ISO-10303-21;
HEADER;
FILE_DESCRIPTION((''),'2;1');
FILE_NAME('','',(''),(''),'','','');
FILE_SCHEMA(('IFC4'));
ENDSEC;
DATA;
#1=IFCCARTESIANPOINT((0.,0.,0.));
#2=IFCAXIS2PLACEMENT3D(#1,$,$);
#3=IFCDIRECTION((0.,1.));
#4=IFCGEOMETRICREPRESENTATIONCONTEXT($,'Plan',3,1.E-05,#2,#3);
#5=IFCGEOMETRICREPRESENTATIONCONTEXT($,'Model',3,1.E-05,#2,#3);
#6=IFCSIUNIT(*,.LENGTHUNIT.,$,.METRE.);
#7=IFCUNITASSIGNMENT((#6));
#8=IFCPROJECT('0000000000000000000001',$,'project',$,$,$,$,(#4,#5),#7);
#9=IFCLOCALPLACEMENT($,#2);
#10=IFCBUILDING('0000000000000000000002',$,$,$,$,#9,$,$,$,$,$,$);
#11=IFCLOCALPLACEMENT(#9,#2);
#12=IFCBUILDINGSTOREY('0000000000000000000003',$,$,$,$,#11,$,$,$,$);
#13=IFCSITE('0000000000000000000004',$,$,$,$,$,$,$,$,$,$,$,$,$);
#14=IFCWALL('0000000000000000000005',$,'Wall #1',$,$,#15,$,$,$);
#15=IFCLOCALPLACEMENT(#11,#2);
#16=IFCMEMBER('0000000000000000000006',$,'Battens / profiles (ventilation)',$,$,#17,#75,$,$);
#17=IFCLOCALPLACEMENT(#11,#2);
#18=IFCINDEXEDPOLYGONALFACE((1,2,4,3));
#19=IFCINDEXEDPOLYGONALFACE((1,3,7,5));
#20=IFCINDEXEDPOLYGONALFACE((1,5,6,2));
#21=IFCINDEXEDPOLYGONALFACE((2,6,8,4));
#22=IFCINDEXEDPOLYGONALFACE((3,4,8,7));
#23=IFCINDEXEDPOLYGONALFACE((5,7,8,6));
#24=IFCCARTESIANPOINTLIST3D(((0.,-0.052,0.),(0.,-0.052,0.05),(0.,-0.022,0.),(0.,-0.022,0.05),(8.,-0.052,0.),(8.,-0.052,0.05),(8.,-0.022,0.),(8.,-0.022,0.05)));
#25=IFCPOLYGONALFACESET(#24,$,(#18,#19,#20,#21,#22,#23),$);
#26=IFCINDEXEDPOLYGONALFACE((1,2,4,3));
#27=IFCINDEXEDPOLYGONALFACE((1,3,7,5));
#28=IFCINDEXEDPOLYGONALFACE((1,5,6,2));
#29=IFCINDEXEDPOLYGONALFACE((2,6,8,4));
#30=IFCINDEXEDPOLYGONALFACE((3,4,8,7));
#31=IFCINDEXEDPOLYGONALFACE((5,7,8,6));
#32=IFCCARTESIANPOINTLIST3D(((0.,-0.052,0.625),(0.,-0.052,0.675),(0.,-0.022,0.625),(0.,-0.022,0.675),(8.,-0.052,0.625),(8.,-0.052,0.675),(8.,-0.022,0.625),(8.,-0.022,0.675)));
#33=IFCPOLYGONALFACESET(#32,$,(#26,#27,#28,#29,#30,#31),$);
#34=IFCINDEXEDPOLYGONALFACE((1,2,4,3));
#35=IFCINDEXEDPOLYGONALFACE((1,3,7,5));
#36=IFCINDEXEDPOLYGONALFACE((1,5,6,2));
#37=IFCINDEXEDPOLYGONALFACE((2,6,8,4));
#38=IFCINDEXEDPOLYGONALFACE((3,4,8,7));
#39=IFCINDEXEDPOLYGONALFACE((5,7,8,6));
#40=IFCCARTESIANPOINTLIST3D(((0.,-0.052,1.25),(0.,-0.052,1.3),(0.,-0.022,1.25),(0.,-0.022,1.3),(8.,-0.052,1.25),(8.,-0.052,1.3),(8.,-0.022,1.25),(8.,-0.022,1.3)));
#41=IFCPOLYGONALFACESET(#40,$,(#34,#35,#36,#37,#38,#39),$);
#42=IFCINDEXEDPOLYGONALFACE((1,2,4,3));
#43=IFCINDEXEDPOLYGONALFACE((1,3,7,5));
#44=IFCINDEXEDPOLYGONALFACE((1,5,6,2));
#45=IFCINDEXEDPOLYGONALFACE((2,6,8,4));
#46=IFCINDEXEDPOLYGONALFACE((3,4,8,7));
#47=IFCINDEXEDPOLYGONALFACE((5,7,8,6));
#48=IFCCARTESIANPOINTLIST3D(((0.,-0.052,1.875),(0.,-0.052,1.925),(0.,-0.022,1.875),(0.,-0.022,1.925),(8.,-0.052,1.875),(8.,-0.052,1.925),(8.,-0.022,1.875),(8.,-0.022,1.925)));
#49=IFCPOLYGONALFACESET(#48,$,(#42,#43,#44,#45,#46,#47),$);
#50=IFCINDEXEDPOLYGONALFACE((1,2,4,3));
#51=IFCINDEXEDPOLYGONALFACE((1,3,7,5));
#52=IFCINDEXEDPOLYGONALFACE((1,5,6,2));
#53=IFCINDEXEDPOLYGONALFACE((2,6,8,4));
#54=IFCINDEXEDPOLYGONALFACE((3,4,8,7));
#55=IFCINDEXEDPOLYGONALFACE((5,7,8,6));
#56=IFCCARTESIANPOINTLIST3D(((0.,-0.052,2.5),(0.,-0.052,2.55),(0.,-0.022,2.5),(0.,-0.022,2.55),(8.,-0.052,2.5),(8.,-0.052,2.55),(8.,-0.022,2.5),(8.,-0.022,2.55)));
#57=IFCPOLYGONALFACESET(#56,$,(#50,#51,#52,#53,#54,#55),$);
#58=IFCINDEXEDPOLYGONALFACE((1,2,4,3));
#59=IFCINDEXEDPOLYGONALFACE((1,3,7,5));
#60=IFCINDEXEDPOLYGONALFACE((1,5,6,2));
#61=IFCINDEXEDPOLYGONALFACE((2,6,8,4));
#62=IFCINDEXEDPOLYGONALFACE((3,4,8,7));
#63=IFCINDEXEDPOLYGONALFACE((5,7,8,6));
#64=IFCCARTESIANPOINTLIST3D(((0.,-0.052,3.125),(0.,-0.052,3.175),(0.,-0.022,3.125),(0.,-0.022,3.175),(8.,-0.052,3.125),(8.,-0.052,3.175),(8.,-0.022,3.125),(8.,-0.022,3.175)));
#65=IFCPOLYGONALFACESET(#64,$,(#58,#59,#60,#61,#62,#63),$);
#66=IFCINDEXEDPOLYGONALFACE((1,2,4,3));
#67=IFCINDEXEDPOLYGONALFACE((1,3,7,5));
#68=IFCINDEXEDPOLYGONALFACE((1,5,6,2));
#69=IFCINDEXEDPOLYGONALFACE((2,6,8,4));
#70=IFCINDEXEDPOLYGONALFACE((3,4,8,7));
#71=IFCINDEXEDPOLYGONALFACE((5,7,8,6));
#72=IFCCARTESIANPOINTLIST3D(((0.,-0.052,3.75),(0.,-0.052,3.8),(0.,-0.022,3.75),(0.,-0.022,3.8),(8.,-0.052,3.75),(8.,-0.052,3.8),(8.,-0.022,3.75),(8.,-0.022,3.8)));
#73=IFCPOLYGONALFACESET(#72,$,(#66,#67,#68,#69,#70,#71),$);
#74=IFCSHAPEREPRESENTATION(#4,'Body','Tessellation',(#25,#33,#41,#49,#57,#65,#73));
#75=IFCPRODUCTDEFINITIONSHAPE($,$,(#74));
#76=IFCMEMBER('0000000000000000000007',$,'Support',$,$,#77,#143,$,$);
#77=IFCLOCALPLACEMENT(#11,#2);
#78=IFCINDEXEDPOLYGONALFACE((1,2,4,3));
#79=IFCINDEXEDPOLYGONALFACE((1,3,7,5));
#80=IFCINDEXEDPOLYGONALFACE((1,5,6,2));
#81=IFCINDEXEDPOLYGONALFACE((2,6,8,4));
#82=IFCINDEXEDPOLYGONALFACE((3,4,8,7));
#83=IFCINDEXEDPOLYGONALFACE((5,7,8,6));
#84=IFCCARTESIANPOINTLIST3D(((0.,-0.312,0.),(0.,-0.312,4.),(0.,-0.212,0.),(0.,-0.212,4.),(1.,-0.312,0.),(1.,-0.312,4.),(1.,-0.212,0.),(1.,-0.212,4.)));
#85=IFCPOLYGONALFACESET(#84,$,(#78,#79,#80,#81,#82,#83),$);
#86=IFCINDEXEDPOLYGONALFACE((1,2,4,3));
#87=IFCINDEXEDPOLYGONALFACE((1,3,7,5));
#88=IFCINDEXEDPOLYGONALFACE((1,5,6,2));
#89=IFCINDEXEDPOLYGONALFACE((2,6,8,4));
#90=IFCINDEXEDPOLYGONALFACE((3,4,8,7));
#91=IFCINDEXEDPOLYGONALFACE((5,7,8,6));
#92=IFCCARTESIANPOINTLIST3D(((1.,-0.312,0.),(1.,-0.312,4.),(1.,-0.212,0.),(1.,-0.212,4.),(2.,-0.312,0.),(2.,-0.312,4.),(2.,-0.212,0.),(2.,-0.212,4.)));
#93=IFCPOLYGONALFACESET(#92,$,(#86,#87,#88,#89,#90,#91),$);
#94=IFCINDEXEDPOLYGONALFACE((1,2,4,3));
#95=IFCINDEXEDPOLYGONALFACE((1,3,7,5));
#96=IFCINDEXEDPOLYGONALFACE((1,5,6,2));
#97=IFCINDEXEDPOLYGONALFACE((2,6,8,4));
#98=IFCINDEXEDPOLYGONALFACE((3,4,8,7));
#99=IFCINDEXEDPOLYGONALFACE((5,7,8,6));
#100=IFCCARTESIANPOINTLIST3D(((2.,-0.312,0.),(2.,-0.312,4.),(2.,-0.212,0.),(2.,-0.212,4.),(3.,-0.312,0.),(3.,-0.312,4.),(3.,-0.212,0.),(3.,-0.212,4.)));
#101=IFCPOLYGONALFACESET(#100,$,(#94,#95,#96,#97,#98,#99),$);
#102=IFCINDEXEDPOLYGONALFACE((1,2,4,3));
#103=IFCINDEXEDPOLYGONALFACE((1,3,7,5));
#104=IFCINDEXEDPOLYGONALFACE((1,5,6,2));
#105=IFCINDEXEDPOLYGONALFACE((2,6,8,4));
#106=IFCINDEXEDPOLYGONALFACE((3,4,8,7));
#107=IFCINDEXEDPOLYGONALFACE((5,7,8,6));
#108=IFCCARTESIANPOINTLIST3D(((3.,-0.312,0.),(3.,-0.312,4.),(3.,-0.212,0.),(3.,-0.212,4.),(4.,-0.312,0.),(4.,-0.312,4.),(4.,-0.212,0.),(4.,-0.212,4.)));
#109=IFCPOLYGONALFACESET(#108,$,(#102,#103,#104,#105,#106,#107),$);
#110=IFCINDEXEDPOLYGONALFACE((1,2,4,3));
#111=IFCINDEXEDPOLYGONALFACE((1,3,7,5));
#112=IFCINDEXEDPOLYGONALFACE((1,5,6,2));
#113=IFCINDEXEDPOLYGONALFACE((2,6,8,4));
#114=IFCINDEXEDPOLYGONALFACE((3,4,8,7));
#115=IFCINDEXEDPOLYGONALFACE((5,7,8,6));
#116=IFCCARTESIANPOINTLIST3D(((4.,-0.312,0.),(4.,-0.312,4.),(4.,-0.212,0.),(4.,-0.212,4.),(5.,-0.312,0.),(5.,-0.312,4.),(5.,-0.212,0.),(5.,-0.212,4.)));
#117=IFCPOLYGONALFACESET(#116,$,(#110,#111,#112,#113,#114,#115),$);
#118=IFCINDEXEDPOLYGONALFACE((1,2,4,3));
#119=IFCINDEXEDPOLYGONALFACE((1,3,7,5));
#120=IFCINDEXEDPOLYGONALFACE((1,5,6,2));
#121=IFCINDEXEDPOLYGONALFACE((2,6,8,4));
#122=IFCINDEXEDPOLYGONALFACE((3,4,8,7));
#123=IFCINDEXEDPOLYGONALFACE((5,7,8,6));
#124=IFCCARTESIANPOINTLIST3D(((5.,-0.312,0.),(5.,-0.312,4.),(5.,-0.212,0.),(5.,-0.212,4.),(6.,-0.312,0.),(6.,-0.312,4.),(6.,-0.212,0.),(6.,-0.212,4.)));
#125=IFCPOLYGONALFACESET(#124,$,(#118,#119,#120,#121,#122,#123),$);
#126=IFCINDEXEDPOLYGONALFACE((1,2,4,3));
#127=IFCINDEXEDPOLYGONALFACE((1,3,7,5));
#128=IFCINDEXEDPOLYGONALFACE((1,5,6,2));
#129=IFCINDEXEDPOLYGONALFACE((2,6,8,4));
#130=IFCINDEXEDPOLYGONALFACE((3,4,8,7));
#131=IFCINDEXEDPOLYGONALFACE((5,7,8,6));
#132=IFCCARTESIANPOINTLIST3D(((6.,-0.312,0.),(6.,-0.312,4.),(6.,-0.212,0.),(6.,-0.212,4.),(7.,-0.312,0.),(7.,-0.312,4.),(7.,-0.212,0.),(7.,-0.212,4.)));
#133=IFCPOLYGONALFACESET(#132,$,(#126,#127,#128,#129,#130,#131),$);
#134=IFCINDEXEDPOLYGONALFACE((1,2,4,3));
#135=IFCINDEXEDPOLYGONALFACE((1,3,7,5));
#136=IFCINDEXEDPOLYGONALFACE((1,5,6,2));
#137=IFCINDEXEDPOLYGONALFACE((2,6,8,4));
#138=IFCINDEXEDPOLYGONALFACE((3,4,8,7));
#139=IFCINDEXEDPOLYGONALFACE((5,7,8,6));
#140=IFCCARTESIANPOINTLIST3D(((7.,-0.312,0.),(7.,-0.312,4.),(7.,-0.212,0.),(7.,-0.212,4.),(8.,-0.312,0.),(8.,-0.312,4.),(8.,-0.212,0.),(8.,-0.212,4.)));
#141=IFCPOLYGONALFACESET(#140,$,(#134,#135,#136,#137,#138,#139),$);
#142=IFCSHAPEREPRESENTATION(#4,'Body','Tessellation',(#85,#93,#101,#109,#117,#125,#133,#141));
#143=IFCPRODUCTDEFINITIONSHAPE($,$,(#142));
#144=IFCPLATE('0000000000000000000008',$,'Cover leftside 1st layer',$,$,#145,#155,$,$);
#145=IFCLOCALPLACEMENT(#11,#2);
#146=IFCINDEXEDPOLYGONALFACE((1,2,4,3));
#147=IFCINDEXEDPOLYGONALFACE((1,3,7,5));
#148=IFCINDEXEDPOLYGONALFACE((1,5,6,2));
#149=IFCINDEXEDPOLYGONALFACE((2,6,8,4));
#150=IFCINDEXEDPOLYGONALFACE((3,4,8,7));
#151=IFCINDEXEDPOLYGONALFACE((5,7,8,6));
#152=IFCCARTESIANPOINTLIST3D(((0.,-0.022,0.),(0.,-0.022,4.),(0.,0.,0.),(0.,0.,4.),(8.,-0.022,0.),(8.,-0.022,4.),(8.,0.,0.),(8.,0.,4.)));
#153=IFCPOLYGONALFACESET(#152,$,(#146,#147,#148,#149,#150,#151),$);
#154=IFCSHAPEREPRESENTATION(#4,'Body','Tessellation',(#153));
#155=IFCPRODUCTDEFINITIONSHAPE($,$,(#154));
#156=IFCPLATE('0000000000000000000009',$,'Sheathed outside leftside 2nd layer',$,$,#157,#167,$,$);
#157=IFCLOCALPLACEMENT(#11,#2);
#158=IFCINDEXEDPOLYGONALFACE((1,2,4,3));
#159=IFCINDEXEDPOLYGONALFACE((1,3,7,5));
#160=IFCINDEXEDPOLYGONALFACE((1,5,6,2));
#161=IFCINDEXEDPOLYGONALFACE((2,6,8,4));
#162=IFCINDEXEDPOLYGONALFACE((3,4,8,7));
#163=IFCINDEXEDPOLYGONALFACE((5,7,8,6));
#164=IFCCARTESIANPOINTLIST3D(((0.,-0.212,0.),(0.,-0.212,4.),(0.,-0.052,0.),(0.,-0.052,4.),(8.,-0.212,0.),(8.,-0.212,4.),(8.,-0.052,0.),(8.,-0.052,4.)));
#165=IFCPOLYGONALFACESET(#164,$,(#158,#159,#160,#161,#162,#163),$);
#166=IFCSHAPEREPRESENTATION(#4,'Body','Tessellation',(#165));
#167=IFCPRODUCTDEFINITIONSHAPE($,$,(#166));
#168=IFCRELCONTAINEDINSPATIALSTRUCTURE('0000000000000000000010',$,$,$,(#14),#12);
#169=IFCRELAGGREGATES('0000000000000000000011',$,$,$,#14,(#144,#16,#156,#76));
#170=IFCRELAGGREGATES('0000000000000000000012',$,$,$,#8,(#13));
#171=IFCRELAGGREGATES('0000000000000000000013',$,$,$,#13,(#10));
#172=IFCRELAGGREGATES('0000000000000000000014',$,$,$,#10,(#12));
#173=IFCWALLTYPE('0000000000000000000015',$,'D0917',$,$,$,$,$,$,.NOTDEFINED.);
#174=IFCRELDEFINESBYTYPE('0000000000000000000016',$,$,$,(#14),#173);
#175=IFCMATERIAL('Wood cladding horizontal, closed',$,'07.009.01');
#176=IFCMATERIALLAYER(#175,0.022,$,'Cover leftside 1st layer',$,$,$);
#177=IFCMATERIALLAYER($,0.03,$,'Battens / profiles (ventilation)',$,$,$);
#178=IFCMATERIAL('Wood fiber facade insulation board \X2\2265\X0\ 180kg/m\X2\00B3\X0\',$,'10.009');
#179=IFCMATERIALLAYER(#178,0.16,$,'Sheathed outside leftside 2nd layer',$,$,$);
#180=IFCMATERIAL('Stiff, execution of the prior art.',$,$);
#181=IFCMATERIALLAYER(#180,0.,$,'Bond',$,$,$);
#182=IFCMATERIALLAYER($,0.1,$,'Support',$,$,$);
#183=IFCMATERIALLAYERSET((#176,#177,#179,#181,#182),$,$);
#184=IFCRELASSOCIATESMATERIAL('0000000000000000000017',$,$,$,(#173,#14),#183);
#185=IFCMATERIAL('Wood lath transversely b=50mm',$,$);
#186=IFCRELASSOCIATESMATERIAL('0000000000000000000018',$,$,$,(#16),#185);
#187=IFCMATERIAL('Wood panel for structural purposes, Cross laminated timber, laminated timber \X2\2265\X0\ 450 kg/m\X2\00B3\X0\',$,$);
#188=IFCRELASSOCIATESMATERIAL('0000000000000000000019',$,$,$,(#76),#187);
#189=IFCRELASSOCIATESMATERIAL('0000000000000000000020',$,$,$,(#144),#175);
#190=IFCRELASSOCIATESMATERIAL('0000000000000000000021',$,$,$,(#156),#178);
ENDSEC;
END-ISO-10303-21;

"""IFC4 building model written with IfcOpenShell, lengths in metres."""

from ifc_helpers import new_model, si_unit, direction, frame, frame_2d, origin, origin_with_axes, place, context, project, spatial, rectangle, extrude, material, layer, layer_set, type_object, element, aggregate, save


model = new_model("IFC4")

# Units and contexts
plan_context = context("Plan", 3, precision=1e-05, world=origin(), true_north=direction((0.0, 1.0)))
model_context = context("Model", 3, precision=1e-05, world=origin(), true_north=direction((0.0, 1.0)))
ifc_project = project(units=[si_unit("LENGTHUNIT", "METRE")], contexts=[plan_context, model_context])

# Site, building, storey
site = spatial("IfcSite", under=ifc_project)
building_placement = place(None, origin())
building = spatial("IfcBuilding", under=site, at=building_placement)
storey_placement = place(building_placement, origin())
storey = spatial("IfcBuildingStorey", under=building, at=storey_placement)

# Wall, members, plates
ifc_material_1 = material(Name="Wood cladding horizontal, closed", Category="07.009.01")
ifc_layer_1 = layer(ifc_material_1, 0.022, Name="Cover leftside 1st layer")
ifc_layer_2 = layer(None, 0.03, Name="Battens / profiles (ventilation)")
ifc_material_2 = material(Name="Wood fiber facade insulation board ≥ 180kg/m³", Category="10.009")
ifc_layer_3 = layer(ifc_material_2, 0.16, Name="Sheathed outside leftside 2nd layer")
ifc_material_3 = material(Name="Stiff, execution of the prior art.")
ifc_layer_4 = layer(ifc_material_3, 0.0, Name="Bond")
ifc_layer_5 = layer(None, 0.1, Name="Support")
ifc_layer_set = layer_set([ifc_layer_1, ifc_layer_2, ifc_layer_3, ifc_layer_4, ifc_layer_5])
wall_type = type_object("IfcWallType", Name="D0917", PredefinedType="NOTDEFINED", material=ifc_layer_set)
wall_placement = place(None, frame((0.0, 0.0, 0.0), z_axis=(0.0, -1.0, 0.0), x_axis=(1.0, 0.0, 0.0)))
wall = element("IfcWall", 1, at=wall_placement, inside=storey, type_object=wall_type, material=ifc_layer_set, Name="Wall #1")
ifc_material_4 = material(Name="Wood lath transversely b=50mm")
member_1_placement = place(wall_placement, origin())
member_1 = element("IfcMember", 2, at=member_1_placement, material=ifc_material_4, Name="Battens / profiles (ventilation)", context=plan_context, shape_type="SweptSolid", body=[
    extrude(rectangle(XDim=0.05, YDim=0.03, at=frame_2d((0.025, 0.015), x_axis=(1.0, 0.0))), frame((0.0, 0.0, 0.022), z_axis=(1.0, 0.0, 0.0), x_axis=(0.0, 1.0, 0.0)), (0.0, 0.0, 1.0), 8.0),
    extrude(rectangle(XDim=0.05, YDim=0.03, at=frame_2d((0.025, 0.015), x_axis=(1.0, 0.0))), frame((0.0, 0.625, 0.022), z_axis=(1.0, 0.0, 0.0), x_axis=(0.0, 1.0, 0.0)), (0.0, 0.0, 1.0), 8.0),
    extrude(rectangle(XDim=0.05, YDim=0.03, at=frame_2d((0.025, 0.015), x_axis=(1.0, 0.0))), frame((0.0, 1.25, 0.022), z_axis=(1.0, 0.0, 0.0), x_axis=(0.0, 1.0, 0.0)), (0.0, 0.0, 1.0), 8.0),
    extrude(rectangle(XDim=0.05, YDim=0.03, at=frame_2d((0.025, 0.015), x_axis=(1.0, 0.0))), frame((0.0, 1.875, 0.022), z_axis=(1.0, 0.0, 0.0), x_axis=(0.0, 1.0, 0.0)), (0.0, 0.0, 1.0), 8.0),
    extrude(rectangle(XDim=0.05, YDim=0.03, at=frame_2d((0.025, 0.015), x_axis=(1.0, 0.0))), frame((0.0, 2.5, 0.022), z_axis=(1.0, 0.0, 0.0), x_axis=(0.0, 1.0, 0.0)), (0.0, 0.0, 1.0), 8.0),
    extrude(rectangle(XDim=0.05, YDim=0.03, at=frame_2d((0.025, 0.015), x_axis=(1.0, 0.0))), frame((0.0, 3.125, 0.022), z_axis=(1.0, 0.0, 0.0), x_axis=(0.0, 1.0, 0.0)), (0.0, 0.0, 1.0), 8.0),
    extrude(rectangle(XDim=0.05, YDim=0.03, at=frame_2d((0.025, 0.015), x_axis=(1.0, 0.0))), frame((0.0, 3.75, 0.022), z_axis=(1.0, 0.0, 0.0), x_axis=(0.0, 1.0, 0.0)), (0.0, 0.0, 1.0), 8.0),
])
ifc_material_5 = material(Name="Wood panel for structural purposes, Cross laminated timber, laminated timber ≥ 450 kg/m³")
member_2_placement = place(wall_placement, origin())
member_2 = element("IfcMember", 3, at=member_2_placement, material=ifc_material_5, Name="Support", context=plan_context, shape_type="SweptSolid", body=[
    extrude(rectangle(XDim=1.0, YDim=0.1, at=frame_2d((0.5, 0.05), x_axis=(1.0, 0.0))), frame((0.0, 4.0, 0.212), z_axis=(0.0, -1.0, 0.0), x_axis=(1.0, 0.0, 0.0)), (0.0, 0.0, 1.0), 4.0),
    extrude(rectangle(XDim=1.0, YDim=0.1, at=frame_2d((0.5, 0.05), x_axis=(1.0, 0.0))), frame((1.0, 4.0, 0.212), z_axis=(0.0, -1.0, 0.0), x_axis=(1.0, 0.0, 0.0)), (0.0, 0.0, 1.0), 4.0),
    extrude(rectangle(XDim=1.0, YDim=0.1, at=frame_2d((0.5, 0.05), x_axis=(1.0, 0.0))), frame((2.0, 4.0, 0.212), z_axis=(0.0, -1.0, 0.0), x_axis=(1.0, 0.0, 0.0)), (0.0, 0.0, 1.0), 4.0),
    extrude(rectangle(XDim=1.0, YDim=0.1, at=frame_2d((0.5, 0.05), x_axis=(1.0, 0.0))), frame((3.0, 4.0, 0.212), z_axis=(0.0, -1.0, 0.0), x_axis=(1.0, 0.0, 0.0)), (0.0, 0.0, 1.0), 4.0),
    extrude(rectangle(XDim=1.0, YDim=0.1, at=frame_2d((0.5, 0.05), x_axis=(1.0, 0.0))), frame((4.0, 4.0, 0.212), z_axis=(0.0, -1.0, 0.0), x_axis=(1.0, 0.0, 0.0)), (0.0, 0.0, 1.0), 4.0),
    extrude(rectangle(XDim=1.0, YDim=0.1, at=frame_2d((0.5, 0.05), x_axis=(1.0, 0.0))), frame((5.0, 4.0, 0.212), z_axis=(0.0, -1.0, 0.0), x_axis=(1.0, 0.0, 0.0)), (0.0, 0.0, 1.0), 4.0),
    extrude(rectangle(XDim=1.0, YDim=0.1, at=frame_2d((0.5, 0.05), x_axis=(1.0, 0.0))), frame((6.0, 4.0, 0.212), z_axis=(0.0, -1.0, 0.0), x_axis=(1.0, 0.0, 0.0)), (0.0, 0.0, 1.0), 4.0),
    extrude(rectangle(XDim=1.0, YDim=0.1, at=frame_2d((0.5, 0.05), x_axis=(1.0, 0.0))), frame((7.0, 4.0, 0.212), z_axis=(0.0, -1.0, 0.0), x_axis=(1.0, 0.0, 0.0)), (0.0, 0.0, 1.0), 4.0),
])
plate_1_placement = place(wall_placement, origin())
plate_1 = element("IfcPlate", 4, at=plate_1_placement, material=ifc_material_1, Name="Cover leftside 1st layer", context=plan_context, shape_type="SweptSolid", body=[
    extrude(rectangle(XDim=8.0, YDim=4.0, at=frame_2d((4.0, 2.0), x_axis=(1.0, 0.0))), origin_with_axes(), (0.0, 0.0, 1.0), 0.022),
])
plate_2_placement = place(wall_placement, origin())
plate_2 = element("IfcPlate", 5, at=plate_2_placement, material=ifc_material_2, Name="Sheathed outside leftside 2nd layer", context=plan_context, shape_type="SweptSolid", body=[
    extrude(rectangle(XDim=8.0, YDim=4.0, at=frame_2d((4.0, 2.0), x_axis=(1.0, 0.0))), frame((0.0, 0.0, 0.052), z_axis=(0.0, 0.0, 1.0), x_axis=(1.0, 0.0, 0.0)), (0.0, 0.0, 1.0), 0.16),
])
aggregate(wall, [plate_1, member_1, plate_2, member_2])

save(model, "model.ifc")
